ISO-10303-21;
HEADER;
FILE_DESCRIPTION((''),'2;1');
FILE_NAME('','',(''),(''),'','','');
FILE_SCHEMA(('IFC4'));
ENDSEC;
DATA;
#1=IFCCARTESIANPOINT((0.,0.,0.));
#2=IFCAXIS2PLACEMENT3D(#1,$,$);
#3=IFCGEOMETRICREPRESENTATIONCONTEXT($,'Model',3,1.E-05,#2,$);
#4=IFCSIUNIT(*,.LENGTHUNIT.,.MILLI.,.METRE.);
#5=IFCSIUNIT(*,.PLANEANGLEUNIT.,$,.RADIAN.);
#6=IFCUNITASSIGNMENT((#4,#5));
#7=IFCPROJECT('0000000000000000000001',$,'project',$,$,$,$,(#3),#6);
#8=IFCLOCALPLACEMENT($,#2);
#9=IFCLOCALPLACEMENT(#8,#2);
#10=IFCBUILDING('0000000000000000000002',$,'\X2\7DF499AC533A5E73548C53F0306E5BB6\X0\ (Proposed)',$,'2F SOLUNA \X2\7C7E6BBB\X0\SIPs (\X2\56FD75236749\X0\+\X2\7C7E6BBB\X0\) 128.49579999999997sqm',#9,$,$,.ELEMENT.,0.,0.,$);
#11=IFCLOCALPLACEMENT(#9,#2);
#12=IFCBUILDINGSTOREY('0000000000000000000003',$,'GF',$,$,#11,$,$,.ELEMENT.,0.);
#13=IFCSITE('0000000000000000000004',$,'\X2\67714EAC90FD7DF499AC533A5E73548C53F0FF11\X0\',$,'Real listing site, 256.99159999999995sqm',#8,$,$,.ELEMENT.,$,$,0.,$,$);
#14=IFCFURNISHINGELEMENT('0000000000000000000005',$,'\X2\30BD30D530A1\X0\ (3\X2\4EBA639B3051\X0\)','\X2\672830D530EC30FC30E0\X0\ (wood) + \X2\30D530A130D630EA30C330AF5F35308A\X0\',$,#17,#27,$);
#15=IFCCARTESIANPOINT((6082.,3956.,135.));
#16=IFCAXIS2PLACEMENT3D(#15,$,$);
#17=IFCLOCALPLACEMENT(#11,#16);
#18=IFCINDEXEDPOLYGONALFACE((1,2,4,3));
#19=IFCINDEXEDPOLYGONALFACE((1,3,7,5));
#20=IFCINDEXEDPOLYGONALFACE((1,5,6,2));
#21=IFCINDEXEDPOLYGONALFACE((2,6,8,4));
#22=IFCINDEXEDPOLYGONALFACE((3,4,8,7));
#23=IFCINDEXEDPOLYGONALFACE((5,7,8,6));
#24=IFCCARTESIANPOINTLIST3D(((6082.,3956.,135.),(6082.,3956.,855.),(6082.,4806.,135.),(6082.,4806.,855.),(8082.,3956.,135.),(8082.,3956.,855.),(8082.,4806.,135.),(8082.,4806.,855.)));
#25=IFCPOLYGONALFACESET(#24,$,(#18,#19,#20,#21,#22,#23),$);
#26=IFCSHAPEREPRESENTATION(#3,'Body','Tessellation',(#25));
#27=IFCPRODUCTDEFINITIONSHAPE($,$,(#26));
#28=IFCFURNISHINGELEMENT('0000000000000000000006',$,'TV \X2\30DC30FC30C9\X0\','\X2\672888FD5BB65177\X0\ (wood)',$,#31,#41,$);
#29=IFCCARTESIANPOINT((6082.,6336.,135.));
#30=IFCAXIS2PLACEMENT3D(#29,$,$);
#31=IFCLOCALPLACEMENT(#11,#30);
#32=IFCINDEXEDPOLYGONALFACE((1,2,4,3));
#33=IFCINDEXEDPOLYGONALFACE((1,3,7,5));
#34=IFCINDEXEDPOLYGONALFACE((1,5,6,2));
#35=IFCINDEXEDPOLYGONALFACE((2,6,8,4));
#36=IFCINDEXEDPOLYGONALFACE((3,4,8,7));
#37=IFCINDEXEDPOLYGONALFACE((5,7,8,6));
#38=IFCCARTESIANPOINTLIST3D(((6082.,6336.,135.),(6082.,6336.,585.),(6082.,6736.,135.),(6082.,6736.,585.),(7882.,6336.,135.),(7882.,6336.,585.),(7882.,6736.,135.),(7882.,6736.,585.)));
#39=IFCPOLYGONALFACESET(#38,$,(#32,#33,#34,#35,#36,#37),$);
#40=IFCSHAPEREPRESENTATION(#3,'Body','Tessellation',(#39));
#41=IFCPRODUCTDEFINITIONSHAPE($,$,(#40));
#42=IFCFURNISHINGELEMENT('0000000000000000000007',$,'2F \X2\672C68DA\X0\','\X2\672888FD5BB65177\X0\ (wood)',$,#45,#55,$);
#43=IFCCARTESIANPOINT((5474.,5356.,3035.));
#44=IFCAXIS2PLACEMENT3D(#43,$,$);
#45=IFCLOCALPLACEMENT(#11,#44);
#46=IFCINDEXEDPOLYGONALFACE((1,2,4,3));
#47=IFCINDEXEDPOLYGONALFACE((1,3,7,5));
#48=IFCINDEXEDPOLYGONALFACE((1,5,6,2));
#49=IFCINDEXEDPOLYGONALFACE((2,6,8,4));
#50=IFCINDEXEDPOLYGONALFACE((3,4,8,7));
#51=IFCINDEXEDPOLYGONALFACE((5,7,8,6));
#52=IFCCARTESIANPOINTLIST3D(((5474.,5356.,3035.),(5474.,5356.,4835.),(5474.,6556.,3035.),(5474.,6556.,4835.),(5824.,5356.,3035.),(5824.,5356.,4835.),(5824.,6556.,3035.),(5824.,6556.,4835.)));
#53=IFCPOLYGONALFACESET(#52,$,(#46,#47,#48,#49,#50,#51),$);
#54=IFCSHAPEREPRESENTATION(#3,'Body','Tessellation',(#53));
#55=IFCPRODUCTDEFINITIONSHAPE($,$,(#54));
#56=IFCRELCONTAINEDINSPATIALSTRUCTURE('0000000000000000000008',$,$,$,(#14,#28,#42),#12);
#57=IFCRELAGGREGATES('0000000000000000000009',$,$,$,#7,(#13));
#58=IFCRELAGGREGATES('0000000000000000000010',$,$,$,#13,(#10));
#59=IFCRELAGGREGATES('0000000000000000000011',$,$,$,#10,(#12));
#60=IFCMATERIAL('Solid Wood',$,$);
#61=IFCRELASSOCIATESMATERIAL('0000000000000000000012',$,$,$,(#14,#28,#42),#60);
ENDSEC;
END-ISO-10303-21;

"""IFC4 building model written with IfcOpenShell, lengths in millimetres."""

from ifc_helpers import new_model, si_unit, frame, frame_2d, origin, place, context, project, spatial, rectangle, extrude, material, element, save


model = new_model("IFC4")

# Units and contexts
model_context = context("Model", 3, precision=1e-05, world=origin())
ifc_project = project(units=[si_unit("LENGTHUNIT", "METRE", prefix="MILLI"), si_unit("PLANEANGLEUNIT", "RADIAN")], contexts=[model_context])

# Site, building, storey
site_placement = place(None, origin())
site = spatial("IfcSite", under=ifc_project, at=site_placement, Name="東京都練馬区平和台１", ObjectType="Real listing site, 256.99159999999995sqm", CompositionType="ELEMENT", RefElevation=0.0)
building_placement = place(site_placement, origin())
building = spatial("IfcBuilding", under=site, at=building_placement, Name="練馬区平和台の家 (Proposed)", ObjectType="2F SOLUNA 籾殻SIPs (国産杉+籾殻) 128.49579999999997sqm", CompositionType="ELEMENT", ElevationOfRefHeight=0.0, ElevationOfTerrain=0.0)
storey_placement = place(building_placement, origin())
storey = spatial("IfcBuildingStorey", under=building, at=storey_placement, Name="GF", CompositionType="ELEMENT", Elevation=0.0)

# Shared definitions
ifc_material_1 = material(Name="Solid Wood")

# Furnishing elements
furnishing_1_placement = place(storey_placement, frame((6082.0, 3956.0, 135.0)))
element("IfcFurnishingElement", 1, at=furnishing_1_placement, inside=storey, material=ifc_material_1, Name="ソファ (3人掛け)", Description="木フレーム (wood) + ファブリック張り", context=model_context, shape_type="SweptSolid", body=[
    extrude(rectangle(XDim=2000.0, YDim=850.0, at=frame_2d((1000.0, 425.0))), frame((6082.0, 3956.0, 135.0)), (0.0, 0.0, 1.0), 720.0),
])
furnishing_2_placement = place(storey_placement, frame((6082.0, 6336.0, 135.0)))
element("IfcFurnishingElement", 2, at=furnishing_2_placement, inside=storey, material=ifc_material_1, Name="TV ボード", Description="木製家具 (wood)", context=model_context, shape_type="SweptSolid", body=[
    extrude(rectangle(XDim=1800.0, YDim=400.0, at=frame_2d((900.0, 200.0))), frame((6082.0, 6336.0, 135.0)), (0.0, 0.0, 1.0), 450.0),
])
furnishing_3_placement = place(storey_placement, frame((5474.0, 5356.0, 3035.0)))
element("IfcFurnishingElement", 3, at=furnishing_3_placement, inside=storey, material=ifc_material_1, Name="2F 本棚", Description="木製家具 (wood)", context=model_context, shape_type="SweptSolid", body=[
    extrude(rectangle(XDim=350.0, YDim=1200.0, at=frame_2d((175.0, 600.0))), frame((5474.0, 5356.0, 3035.0)), (0.0, 0.0, 1.0), 1800.0),
])

save(model, "model.ifc")
